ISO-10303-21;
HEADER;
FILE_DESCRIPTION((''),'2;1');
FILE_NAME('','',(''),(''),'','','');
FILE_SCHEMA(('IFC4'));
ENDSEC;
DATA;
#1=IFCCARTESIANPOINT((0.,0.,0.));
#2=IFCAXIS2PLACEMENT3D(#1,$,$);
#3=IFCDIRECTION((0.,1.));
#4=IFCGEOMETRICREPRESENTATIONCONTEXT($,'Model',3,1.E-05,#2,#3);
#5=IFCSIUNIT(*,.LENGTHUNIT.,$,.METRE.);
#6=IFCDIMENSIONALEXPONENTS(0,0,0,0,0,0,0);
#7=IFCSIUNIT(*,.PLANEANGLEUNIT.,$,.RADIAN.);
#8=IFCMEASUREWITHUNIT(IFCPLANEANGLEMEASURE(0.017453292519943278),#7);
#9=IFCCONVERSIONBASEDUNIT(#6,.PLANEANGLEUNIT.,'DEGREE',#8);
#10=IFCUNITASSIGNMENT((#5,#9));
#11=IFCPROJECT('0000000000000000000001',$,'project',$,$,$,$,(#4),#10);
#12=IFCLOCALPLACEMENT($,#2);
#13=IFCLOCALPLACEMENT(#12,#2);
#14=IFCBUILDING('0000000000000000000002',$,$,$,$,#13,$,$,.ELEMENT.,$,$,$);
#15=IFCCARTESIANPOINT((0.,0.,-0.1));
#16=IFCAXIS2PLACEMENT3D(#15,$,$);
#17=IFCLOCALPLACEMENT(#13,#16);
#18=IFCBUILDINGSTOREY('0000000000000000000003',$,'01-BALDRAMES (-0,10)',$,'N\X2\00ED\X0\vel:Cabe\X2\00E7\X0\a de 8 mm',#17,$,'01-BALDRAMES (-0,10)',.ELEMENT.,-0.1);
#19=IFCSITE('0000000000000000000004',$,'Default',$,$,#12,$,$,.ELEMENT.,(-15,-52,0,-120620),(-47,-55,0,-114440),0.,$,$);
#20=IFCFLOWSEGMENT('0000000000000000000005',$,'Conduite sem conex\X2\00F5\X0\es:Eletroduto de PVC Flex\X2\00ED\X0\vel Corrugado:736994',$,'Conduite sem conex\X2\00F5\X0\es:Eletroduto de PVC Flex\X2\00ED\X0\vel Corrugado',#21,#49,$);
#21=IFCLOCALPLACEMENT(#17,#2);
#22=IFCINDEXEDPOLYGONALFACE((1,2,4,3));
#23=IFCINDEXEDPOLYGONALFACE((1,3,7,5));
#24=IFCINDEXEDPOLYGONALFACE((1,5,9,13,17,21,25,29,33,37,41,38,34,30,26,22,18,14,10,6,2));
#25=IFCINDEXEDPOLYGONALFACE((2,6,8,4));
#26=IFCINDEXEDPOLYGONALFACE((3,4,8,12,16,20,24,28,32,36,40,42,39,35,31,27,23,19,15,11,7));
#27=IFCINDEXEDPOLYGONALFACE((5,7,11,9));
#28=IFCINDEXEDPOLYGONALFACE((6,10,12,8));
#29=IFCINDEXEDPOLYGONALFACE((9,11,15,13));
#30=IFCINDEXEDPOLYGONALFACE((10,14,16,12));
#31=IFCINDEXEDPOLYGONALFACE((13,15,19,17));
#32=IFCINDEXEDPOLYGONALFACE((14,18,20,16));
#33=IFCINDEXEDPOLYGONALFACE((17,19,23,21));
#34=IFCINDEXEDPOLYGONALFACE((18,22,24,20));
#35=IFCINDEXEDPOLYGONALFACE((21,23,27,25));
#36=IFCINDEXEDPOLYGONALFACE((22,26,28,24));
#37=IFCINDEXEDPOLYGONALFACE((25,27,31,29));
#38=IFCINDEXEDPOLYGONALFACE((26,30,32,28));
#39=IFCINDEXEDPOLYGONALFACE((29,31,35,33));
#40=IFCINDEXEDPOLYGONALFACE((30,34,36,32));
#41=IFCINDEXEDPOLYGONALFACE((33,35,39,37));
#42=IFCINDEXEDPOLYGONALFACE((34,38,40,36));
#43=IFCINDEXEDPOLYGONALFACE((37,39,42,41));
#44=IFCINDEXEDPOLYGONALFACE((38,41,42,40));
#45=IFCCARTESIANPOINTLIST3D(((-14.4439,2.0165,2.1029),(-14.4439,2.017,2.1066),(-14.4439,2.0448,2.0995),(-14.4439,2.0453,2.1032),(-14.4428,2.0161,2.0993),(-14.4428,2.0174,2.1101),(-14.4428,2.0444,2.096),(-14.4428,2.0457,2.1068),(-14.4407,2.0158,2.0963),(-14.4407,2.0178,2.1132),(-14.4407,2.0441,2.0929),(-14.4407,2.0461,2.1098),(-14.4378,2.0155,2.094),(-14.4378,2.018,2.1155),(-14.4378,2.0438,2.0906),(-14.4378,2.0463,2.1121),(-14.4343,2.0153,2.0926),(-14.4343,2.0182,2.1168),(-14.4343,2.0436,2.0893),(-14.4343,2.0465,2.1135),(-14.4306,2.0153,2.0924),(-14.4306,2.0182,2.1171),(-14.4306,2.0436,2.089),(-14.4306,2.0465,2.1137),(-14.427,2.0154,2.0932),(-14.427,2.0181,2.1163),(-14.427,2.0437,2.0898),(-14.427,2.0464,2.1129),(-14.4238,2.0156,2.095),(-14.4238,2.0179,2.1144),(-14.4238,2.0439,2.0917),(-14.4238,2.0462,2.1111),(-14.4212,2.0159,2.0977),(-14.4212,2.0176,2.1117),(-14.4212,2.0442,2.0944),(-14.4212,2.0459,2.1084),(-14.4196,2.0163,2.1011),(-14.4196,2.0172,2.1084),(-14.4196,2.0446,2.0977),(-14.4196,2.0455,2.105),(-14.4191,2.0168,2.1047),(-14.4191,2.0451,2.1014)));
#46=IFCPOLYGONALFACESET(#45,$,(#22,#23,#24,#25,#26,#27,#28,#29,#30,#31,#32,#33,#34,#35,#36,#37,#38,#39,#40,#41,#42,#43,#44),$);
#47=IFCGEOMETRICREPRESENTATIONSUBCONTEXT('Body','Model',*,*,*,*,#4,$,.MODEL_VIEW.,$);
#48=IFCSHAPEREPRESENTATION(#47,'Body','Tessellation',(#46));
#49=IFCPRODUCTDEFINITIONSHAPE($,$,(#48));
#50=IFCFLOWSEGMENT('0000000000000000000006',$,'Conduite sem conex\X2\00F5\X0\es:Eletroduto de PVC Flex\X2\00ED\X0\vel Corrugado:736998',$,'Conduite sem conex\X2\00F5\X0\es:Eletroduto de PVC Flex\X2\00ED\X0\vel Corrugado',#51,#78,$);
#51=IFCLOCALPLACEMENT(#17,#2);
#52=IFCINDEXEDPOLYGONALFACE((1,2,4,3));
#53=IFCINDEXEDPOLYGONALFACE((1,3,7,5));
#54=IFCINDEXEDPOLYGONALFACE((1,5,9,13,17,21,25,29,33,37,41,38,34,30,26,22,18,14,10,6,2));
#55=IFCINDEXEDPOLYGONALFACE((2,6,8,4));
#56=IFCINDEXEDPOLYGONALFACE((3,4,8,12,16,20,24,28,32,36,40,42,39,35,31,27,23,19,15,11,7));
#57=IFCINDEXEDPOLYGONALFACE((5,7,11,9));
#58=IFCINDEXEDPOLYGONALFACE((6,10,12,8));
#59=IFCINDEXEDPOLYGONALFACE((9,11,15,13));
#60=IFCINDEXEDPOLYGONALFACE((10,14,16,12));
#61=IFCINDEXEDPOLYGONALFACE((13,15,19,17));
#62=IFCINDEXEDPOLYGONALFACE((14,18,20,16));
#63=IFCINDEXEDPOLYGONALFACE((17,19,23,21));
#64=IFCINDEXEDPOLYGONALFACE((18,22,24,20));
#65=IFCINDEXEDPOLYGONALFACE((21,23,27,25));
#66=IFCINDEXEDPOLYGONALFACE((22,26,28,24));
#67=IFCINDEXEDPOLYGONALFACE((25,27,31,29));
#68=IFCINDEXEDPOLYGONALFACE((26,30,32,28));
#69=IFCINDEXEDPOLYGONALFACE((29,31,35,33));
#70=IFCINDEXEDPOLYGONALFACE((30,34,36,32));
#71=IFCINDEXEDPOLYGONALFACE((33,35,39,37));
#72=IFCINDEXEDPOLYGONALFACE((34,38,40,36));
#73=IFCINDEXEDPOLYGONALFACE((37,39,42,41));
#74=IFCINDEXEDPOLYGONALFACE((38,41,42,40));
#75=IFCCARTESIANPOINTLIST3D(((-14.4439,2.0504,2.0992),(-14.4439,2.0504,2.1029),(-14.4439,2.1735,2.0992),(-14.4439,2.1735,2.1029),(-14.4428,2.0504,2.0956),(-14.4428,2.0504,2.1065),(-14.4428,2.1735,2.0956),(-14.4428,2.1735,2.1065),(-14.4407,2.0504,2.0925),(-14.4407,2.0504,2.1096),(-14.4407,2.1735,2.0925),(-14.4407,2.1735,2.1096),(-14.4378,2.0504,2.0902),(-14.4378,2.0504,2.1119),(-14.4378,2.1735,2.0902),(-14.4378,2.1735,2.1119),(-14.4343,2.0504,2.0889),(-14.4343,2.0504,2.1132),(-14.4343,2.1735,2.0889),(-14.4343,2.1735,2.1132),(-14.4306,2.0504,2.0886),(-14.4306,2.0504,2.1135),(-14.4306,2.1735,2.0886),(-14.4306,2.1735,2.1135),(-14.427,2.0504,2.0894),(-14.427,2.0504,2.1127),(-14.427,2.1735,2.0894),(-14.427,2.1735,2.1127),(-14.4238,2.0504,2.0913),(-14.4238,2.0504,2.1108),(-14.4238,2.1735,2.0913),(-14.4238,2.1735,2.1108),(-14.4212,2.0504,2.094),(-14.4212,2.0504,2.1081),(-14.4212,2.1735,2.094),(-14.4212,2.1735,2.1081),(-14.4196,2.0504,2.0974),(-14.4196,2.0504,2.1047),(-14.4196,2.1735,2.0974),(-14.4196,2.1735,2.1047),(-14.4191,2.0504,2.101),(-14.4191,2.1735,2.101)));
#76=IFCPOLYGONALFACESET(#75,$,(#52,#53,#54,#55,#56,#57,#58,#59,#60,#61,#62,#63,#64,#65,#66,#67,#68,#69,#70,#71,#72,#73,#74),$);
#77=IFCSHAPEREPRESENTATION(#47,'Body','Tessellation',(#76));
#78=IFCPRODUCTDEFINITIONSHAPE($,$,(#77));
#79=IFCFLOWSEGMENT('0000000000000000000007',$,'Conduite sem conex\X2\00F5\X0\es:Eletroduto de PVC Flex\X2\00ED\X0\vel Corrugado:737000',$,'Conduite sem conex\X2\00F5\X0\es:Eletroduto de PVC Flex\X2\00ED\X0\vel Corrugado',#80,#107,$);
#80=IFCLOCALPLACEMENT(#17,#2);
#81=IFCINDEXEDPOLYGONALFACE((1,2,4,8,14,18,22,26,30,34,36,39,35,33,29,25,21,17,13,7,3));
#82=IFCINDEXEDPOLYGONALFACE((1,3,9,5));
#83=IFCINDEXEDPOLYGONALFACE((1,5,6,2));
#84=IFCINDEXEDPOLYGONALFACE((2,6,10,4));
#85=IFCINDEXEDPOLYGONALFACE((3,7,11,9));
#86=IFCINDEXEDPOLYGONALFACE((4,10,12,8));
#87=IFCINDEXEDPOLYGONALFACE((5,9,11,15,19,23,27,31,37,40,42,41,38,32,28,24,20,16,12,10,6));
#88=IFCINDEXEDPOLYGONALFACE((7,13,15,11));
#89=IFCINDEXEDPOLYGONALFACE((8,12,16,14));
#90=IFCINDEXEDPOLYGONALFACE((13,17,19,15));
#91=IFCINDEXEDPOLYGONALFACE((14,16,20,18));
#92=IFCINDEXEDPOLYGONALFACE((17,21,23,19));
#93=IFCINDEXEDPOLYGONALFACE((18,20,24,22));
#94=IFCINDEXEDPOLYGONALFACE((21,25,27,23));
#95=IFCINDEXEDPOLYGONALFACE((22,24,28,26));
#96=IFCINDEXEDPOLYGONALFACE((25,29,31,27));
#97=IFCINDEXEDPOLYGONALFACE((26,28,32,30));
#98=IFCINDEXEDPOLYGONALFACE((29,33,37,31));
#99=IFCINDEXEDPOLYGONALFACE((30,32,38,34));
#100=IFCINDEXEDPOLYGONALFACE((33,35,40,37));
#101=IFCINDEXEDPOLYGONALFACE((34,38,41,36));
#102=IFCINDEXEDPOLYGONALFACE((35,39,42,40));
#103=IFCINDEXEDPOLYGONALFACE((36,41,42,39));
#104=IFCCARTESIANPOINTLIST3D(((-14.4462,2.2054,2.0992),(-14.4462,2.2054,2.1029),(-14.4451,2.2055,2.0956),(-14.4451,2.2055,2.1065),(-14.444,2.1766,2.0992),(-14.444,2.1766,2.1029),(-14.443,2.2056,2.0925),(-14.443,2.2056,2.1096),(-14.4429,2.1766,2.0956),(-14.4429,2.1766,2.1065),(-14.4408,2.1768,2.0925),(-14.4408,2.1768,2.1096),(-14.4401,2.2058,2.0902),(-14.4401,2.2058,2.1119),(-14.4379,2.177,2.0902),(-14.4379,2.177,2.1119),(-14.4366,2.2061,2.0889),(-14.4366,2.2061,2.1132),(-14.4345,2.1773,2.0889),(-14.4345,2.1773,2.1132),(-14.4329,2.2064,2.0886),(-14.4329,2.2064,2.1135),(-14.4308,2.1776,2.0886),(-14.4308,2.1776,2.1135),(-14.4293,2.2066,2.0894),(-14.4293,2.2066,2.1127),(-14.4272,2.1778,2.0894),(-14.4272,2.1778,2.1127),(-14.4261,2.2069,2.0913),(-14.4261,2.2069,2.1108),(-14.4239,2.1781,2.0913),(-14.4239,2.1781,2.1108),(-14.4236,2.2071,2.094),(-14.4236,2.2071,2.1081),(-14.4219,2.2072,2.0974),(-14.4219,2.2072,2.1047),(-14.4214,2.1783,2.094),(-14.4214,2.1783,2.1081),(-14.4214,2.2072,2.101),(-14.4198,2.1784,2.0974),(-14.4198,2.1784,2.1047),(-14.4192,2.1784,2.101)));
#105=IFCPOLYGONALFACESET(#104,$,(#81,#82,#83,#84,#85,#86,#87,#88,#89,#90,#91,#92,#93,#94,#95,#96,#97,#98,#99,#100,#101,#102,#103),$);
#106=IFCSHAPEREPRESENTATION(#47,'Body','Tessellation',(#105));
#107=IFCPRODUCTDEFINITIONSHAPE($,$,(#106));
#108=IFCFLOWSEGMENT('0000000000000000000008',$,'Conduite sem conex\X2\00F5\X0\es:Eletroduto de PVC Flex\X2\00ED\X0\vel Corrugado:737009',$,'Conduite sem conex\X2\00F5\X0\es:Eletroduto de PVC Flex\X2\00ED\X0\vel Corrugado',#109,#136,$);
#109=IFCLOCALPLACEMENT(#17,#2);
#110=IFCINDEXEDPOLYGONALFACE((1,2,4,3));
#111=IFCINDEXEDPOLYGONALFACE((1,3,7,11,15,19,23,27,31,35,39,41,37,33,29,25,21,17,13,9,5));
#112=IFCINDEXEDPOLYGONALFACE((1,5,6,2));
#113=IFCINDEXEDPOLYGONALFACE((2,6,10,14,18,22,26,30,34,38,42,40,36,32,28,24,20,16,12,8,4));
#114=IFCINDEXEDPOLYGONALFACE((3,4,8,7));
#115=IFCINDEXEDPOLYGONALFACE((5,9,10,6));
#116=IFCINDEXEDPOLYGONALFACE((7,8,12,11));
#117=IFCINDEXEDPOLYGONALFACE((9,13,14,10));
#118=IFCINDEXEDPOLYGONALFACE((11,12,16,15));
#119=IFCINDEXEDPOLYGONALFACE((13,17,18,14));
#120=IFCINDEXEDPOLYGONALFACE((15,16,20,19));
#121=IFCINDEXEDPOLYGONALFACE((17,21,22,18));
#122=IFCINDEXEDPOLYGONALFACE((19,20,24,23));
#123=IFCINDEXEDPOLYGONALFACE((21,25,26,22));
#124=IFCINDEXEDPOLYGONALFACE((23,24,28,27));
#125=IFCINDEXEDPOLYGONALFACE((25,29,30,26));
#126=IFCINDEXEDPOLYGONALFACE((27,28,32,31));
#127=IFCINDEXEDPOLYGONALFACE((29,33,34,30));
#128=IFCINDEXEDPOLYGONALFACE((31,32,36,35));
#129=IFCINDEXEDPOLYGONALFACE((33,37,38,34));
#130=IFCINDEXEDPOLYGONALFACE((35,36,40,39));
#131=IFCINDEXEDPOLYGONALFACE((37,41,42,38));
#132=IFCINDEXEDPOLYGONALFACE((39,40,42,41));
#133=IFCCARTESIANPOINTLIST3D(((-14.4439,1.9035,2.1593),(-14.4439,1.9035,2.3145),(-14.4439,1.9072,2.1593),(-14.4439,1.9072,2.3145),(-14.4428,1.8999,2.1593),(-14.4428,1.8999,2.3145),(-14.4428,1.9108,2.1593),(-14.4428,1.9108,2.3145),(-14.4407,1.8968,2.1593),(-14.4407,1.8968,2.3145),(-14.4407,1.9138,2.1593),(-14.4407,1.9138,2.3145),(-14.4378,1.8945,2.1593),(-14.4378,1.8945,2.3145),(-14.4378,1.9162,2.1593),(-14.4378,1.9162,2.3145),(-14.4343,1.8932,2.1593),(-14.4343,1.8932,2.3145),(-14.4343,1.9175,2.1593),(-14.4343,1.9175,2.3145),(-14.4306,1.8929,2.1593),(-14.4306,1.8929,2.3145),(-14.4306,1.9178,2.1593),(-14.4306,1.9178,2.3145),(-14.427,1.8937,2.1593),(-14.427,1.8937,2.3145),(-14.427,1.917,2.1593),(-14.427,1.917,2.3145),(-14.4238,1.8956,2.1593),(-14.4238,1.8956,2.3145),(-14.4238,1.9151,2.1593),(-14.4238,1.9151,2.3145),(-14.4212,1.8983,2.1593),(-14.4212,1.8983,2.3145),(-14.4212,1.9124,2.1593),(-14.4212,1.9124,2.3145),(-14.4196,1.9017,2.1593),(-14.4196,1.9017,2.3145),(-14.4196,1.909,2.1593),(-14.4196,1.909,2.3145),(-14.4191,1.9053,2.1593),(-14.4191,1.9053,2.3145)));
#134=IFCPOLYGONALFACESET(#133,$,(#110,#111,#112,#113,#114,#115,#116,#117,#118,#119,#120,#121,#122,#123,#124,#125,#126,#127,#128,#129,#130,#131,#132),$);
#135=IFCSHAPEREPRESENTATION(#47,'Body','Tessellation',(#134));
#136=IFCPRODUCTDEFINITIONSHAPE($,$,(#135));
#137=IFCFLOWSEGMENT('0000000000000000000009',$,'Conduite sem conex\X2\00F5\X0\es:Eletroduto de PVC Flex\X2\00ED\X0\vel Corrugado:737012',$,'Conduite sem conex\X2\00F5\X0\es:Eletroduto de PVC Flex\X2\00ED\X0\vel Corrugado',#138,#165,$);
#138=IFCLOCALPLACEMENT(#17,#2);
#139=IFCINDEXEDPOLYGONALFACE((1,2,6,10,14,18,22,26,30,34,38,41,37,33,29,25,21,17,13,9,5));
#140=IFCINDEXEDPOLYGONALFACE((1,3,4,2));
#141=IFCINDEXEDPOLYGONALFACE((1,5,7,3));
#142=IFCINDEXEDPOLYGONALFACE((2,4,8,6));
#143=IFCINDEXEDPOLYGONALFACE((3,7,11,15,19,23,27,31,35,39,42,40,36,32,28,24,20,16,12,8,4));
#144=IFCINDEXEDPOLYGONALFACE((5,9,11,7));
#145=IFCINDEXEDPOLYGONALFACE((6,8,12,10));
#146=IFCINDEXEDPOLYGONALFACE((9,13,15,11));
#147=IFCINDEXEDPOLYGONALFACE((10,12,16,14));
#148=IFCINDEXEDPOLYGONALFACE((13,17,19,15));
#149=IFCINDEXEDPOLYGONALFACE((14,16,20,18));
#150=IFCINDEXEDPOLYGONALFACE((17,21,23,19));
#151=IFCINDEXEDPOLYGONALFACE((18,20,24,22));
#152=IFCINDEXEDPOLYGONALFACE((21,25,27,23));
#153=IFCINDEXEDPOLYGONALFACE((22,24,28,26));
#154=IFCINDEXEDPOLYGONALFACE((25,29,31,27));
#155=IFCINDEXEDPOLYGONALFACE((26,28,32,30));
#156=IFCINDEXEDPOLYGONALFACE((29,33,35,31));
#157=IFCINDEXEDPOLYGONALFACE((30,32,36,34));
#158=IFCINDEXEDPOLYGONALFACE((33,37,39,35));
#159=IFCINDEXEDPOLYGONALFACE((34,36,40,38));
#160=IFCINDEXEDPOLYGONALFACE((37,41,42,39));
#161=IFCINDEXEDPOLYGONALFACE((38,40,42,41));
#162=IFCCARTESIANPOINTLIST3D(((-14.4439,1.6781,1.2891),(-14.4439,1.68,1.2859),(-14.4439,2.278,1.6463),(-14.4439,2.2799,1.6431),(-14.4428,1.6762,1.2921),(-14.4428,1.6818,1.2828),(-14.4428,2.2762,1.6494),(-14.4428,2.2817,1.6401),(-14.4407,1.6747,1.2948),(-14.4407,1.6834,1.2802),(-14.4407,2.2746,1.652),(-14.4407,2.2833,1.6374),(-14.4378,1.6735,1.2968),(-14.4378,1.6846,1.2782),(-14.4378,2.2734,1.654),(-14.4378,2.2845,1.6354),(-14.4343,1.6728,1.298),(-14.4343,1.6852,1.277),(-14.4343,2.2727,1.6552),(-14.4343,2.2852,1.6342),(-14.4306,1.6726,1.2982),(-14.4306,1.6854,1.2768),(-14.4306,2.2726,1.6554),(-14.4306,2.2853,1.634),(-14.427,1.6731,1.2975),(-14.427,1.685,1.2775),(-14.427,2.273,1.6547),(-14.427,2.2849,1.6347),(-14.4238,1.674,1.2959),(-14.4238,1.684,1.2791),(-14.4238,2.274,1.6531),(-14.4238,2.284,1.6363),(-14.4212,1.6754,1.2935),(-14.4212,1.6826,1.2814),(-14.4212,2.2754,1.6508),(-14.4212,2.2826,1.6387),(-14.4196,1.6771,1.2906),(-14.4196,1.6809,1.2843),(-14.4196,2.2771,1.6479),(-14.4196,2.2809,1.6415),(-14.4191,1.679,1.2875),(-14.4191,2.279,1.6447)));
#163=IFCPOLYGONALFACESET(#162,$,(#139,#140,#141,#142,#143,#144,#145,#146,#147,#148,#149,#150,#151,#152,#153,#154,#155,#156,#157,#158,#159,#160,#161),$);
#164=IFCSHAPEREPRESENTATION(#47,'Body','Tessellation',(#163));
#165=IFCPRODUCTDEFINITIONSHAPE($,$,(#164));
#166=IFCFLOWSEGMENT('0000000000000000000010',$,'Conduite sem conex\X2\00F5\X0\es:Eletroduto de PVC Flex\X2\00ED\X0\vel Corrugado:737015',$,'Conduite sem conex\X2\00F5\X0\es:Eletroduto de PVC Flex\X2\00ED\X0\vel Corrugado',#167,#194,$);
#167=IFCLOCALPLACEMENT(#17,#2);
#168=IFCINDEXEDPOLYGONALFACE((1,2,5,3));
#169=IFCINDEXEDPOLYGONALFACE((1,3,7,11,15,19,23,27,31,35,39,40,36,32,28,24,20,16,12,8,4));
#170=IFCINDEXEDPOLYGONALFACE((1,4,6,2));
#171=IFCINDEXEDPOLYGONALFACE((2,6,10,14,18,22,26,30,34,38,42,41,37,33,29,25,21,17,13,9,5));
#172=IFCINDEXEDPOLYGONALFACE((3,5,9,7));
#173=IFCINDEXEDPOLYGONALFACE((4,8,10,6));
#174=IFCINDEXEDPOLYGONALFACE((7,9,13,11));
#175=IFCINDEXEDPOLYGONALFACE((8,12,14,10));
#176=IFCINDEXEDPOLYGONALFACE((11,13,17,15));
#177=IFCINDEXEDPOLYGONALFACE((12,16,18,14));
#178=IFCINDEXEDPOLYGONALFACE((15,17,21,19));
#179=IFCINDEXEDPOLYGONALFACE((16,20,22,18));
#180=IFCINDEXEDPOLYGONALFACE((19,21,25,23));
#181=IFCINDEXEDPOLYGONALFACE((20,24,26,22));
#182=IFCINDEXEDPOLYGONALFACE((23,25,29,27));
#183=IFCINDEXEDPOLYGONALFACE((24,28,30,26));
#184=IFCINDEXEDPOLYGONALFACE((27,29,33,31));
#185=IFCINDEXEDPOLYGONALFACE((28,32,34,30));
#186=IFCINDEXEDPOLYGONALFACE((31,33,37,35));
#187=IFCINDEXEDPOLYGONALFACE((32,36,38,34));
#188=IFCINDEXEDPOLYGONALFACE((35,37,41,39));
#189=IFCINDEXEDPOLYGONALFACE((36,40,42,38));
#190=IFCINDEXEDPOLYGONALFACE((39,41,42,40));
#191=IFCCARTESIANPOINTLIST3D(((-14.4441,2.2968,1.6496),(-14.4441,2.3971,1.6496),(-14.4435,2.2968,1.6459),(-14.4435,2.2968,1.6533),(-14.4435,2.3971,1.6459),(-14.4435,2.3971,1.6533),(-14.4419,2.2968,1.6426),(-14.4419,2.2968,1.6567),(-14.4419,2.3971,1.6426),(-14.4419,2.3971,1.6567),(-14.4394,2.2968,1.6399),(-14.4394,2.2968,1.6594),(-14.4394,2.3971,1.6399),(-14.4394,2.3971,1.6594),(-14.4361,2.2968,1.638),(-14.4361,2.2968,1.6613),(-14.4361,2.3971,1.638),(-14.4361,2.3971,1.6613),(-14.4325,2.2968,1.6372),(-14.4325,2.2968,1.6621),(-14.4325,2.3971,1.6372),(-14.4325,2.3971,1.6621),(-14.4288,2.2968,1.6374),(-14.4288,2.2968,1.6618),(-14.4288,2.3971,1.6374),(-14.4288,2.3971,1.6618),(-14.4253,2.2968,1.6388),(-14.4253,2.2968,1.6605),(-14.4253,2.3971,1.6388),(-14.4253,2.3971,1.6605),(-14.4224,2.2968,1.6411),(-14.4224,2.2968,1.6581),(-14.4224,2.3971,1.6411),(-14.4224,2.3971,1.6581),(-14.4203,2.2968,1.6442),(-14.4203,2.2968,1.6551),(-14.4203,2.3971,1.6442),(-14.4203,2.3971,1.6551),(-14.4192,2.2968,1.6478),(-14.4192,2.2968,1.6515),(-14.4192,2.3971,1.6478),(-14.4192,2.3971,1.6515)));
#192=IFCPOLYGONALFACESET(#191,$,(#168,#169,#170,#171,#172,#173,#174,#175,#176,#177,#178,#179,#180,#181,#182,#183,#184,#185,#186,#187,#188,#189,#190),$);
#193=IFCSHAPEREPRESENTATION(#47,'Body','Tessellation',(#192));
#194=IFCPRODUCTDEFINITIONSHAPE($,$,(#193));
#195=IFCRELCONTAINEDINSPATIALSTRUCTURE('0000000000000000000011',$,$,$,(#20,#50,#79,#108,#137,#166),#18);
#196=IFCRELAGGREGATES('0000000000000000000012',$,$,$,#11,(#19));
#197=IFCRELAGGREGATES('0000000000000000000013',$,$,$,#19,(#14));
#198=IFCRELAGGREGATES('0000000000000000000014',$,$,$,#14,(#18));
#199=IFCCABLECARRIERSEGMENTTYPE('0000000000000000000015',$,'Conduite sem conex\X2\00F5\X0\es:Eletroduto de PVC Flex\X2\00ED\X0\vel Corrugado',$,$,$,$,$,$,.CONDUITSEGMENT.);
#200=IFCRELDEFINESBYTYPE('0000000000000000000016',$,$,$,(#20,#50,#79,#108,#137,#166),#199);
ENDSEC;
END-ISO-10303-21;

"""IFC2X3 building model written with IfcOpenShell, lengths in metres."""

from ifc_helpers import new_model, entity, si_unit, converted_unit, direction, frame, frame_2d, origin, place, context, subcontext, project, spatial, circle, extrude, type_object, element, save


model = new_model("IFC2X3")

# Units and contexts
model_context = context("Model", 3, precision=1e-05, world=origin(), true_north=direction((0.0, 1.0)))
body_context = subcontext(model_context, "Body", "Model", "MODEL_VIEW")
ifc_project = project(units=[si_unit("LENGTHUNIT", "METRE"), converted_unit("PLANEANGLEUNIT", "DEGREE", entity("IfcPlaneAngleMeasure", 0.017453292519943278), si_unit("PLANEANGLEUNIT", "RADIAN"), dimensions=[0, 0, 0, 0, 0, 0, 0])], contexts=[model_context])

# Site, building, storey
site_placement = place(None, origin())
site = spatial("IfcSite", under=ifc_project, at=site_placement, Name="Default", CompositionType="ELEMENT", RefLatitude=(-15, -52, 0, -120620), RefLongitude=(-47, -55, 0, -114440), RefElevation=0.0)
building_placement = place(site_placement, origin())
building = spatial("IfcBuilding", under=site, at=building_placement, CompositionType="ELEMENT")
storey_placement = place(building_placement, frame((0.0, 0.0, -0.1)))
storey = spatial("IfcBuildingStorey", under=building, at=storey_placement, Name="01-BALDRAMES (-0,10)", ObjectType="Nível:Cabeça de 8 mm", LongName="01-BALDRAMES (-0,10)", CompositionType="ELEMENT", Elevation=-0.1)

# Flow segments
cable_carrier_segment_type = type_object("IfcCableCarrierSegmentType", Name="Conduite sem conexões:Eletroduto de PVC Flexível Corrugado", PredefinedType="CONDUITSEGMENT")
flow_segment_1_placement = place(storey_placement, origin())
element("IfcFlowSegment", 1, at=flow_segment_1_placement, inside=storey, type_object=cable_carrier_segment_type, Name="Conduite sem conexões:Eletroduto de PVC Flexível Corrugado:736994", ObjectType="Conduite sem conexões:Eletroduto de PVC Flexível Corrugado", context=body_context, shape_type="SweptSolid", body=[
    extrude(circle(Radius=0.0125, at=frame_2d((0.0, 0.0), x_axis=(1.0, 0.0))), frame((-14.4316, 2.0168, 2.1047), z_axis=(0.0, 0.993007, -0.118059), x_axis=(1.0, 0.0, 0.0)), (0.0, 0.0, 1.0), 0.0285),
])
flow_segment_2_placement = place(storey_placement, origin())
element("IfcFlowSegment", 2, at=flow_segment_2_placement, inside=storey, type_object=cable_carrier_segment_type, Name="Conduite sem conexões:Eletroduto de PVC Flexível Corrugado:736998", ObjectType="Conduite sem conexões:Eletroduto de PVC Flexível Corrugado", context=body_context, shape_type="SweptSolid", body=[
    extrude(circle(Radius=0.0125, at=frame_2d((0.0, 0.0), x_axis=(1.0, 0.0))), frame((-14.4316, 2.0504, 2.101), z_axis=(0.0, 1.0, 0.0), x_axis=(1.0, 0.0, 0.0)), (0.0, 0.0, 1.0), 0.1231),
])
flow_segment_3_placement = place(storey_placement, origin())
element("IfcFlowSegment", 3, at=flow_segment_3_placement, inside=storey, type_object=cable_carrier_segment_type, Name="Conduite sem conexões:Eletroduto de PVC Flexível Corrugado:737000", ObjectType="Conduite sem conexões:Eletroduto de PVC Flexível Corrugado", context=body_context, shape_type="SweptSolid", body=[
    extrude(circle(Radius=0.0125, at=frame_2d((0.0, 0.0), x_axis=(1.0, 0.0))), frame((-14.4317, 2.1775, 2.101), z_axis=(-0.074443, 0.997225, 0.0), x_axis=(0.997225, 0.074443, 0.0)), (0.0, 0.0, 1.0), 0.0289),
])
flow_segment_4_placement = place(storey_placement, origin())
element("IfcFlowSegment", 4, at=flow_segment_4_placement, inside=storey, type_object=cable_carrier_segment_type, Name="Conduite sem conexões:Eletroduto de PVC Flexível Corrugado:737009", ObjectType="Conduite sem conexões:Eletroduto de PVC Flexível Corrugado", context=body_context, shape_type="SweptSolid", body=[
    extrude(circle(Radius=0.0125, at=frame_2d((0.0, 0.0), x_axis=(1.0, 0.0))), frame((-14.4316, 1.9053, 2.1593)), (0.0, 0.0, 1.0), 0.1552),
])
flow_segment_5_placement = place(storey_placement, origin())
element("IfcFlowSegment", 5, at=flow_segment_5_placement, inside=storey, type_object=cable_carrier_segment_type, Name="Conduite sem conexões:Eletroduto de PVC Flexível Corrugado:737012", ObjectType="Conduite sem conexões:Eletroduto de PVC Flexível Corrugado", context=body_context, shape_type="SweptSolid", body=[
    extrude(circle(Radius=0.0125, at=frame_2d((0.0, 0.0), x_axis=(1.0, 0.0))), frame((-14.4316, 1.679, 1.2875), z_axis=(0.0, 0.85922, 0.511607), x_axis=(1.0, 0.000001, 0.0)), (0.0, 0.0, 1.0), 0.6983),
])
flow_segment_6_placement = place(storey_placement, origin())
element("IfcFlowSegment", 6, at=flow_segment_6_placement, inside=storey, type_object=cable_carrier_segment_type, Name="Conduite sem conexões:Eletroduto de PVC Flexível Corrugado:737015", ObjectType="Conduite sem conexões:Eletroduto de PVC Flexível Corrugado", context=body_context, shape_type="SweptSolid", body=[
    extrude(circle(Radius=0.0125, at=frame_2d((0.0, 0.0), x_axis=(1.0, 0.0))), frame((-14.4316, 2.2968, 1.6496), z_axis=(0.000002, 1.0, 0.0), x_axis=(-1.0, 0.000002, 0.0)), (0.0, 0.0, 1.0), 0.1003),
])

save(model, "model.ifc")
